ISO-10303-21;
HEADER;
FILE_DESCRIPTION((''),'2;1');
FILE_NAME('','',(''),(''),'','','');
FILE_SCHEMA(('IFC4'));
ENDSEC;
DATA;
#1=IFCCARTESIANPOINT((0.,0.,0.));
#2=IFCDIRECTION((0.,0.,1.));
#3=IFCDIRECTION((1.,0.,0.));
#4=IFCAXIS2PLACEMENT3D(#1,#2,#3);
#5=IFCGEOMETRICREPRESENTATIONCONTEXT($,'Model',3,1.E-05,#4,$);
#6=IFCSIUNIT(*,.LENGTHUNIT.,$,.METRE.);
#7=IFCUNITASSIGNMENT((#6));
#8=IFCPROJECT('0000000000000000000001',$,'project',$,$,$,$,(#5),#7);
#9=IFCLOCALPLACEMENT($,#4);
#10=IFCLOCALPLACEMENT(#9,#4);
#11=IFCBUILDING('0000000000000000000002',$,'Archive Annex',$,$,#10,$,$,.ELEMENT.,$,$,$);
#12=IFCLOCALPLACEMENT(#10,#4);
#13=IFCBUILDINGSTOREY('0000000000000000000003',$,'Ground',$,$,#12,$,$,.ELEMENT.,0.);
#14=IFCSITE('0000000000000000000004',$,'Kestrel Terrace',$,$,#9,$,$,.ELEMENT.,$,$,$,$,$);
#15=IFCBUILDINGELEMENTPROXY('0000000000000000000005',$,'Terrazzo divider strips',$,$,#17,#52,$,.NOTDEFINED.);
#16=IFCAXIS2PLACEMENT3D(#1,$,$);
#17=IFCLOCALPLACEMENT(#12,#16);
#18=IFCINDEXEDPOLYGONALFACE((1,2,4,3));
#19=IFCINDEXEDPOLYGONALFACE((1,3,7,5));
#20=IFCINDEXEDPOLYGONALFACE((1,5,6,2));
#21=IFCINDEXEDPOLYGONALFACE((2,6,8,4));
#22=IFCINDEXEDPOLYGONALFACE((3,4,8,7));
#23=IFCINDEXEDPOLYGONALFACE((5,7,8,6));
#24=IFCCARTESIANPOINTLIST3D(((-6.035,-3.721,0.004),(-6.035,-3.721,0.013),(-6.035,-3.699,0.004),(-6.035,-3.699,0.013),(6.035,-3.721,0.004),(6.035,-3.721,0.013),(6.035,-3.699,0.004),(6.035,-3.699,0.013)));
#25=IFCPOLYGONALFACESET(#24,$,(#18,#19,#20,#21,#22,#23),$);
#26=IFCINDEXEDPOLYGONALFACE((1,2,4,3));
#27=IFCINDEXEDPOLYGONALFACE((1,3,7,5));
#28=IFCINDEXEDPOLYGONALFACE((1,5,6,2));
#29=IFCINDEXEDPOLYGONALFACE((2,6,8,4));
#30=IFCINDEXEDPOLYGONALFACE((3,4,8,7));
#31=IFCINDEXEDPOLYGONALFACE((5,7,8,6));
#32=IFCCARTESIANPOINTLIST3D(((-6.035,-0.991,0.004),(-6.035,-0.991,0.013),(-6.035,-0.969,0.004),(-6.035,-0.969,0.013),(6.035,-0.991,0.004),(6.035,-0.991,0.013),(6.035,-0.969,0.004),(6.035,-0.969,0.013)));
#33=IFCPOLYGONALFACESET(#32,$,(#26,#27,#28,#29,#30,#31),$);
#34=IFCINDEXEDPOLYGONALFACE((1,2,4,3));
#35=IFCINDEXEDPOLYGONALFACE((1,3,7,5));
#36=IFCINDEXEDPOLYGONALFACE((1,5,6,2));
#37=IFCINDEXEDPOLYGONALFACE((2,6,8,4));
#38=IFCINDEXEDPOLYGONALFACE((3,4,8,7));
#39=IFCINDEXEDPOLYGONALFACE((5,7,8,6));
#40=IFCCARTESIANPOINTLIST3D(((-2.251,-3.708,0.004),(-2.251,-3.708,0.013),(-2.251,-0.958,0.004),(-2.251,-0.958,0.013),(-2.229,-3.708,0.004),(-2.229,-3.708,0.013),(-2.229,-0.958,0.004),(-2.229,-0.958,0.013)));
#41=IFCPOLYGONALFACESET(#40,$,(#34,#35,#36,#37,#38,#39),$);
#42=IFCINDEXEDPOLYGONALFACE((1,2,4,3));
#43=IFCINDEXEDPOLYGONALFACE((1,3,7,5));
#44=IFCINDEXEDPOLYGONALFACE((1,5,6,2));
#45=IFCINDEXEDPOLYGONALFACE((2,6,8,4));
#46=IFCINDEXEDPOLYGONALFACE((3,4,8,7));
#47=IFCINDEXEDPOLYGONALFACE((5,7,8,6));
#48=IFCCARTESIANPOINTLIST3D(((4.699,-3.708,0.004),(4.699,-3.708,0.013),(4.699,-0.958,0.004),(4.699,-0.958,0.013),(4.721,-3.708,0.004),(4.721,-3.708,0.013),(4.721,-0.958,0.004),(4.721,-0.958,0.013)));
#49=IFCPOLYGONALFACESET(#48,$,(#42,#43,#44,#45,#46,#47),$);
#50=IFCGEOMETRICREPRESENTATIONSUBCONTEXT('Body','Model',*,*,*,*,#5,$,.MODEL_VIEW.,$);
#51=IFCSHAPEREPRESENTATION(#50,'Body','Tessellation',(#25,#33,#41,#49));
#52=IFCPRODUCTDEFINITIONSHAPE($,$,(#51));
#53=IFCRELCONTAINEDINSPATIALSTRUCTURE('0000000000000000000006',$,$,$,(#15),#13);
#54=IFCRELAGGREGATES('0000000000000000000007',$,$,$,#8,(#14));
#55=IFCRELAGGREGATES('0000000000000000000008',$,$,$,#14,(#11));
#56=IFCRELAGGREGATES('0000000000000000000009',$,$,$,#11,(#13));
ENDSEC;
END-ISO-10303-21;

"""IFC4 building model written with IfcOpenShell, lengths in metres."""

from ifc_helpers import new_model, si_unit, frame, origin_with_axes, origin_2d, place, context, subcontext, project, spatial, rectangle, extrude, element, save


model = new_model("IFC4")

# Units and contexts
model_context = context("Model", 3, precision=1e-05, world=origin_with_axes())
body_context = subcontext(model_context, "Body", "Model", "MODEL_VIEW")
ifc_project = project(units=[si_unit("LENGTHUNIT", "METRE")], contexts=[model_context])

# Site, building, storey
site_placement = place(None, origin_with_axes())
site = spatial("IfcSite", under=ifc_project, at=site_placement, Name="Kestrel Terrace", CompositionType="ELEMENT")
building_placement = place(site_placement, origin_with_axes())
building = spatial("IfcBuilding", under=site, at=building_placement, Name="Archive Annex", CompositionType="ELEMENT")
storey_placement = place(building_placement, origin_with_axes())
storey = spatial("IfcBuildingStorey", under=building, at=storey_placement, Name="Ground", CompositionType="ELEMENT", Elevation=0.0)

# Building element proxy
proxy_1_placement = place(storey_placement, origin_with_axes())
element("IfcBuildingElementProxy", 1, at=proxy_1_placement, inside=storey, Name="Terrazzo divider strips", PredefinedType="NOTDEFINED", context=body_context, shape_type="SweptSolid", body=[
    extrude(rectangle(XDim=12.07, YDim=0.022, at=origin_2d()), frame((0.0, -3.71, 0.004), z_axis=(0.0, 0.0, 1.0), x_axis=(1.0, 0.0, 0.0)), (0.0, 0.0, 1.0), 0.009),
    extrude(rectangle(XDim=12.07, YDim=0.022, at=origin_2d()), frame((0.0, -0.98, 0.004), z_axis=(0.0, 0.0, 1.0), x_axis=(1.0, 0.0, 0.0)), (0.0, 0.0, 1.0), 0.009),
    extrude(rectangle(XDim=0.022, YDim=2.75, at=origin_2d()), frame((-2.24, -2.333, 0.004), z_axis=(0.0, 0.0, 1.0), x_axis=(1.0, 0.0, 0.0)), (0.0, 0.0, 1.0), 0.009),
    extrude(rectangle(XDim=0.022, YDim=2.75, at=origin_2d()), frame((4.71, -2.333, 0.004), z_axis=(0.0, 0.0, 1.0), x_axis=(1.0, 0.0, 0.0)), (0.0, 0.0, 1.0), 0.009),
])

save(model, "model.ifc")
